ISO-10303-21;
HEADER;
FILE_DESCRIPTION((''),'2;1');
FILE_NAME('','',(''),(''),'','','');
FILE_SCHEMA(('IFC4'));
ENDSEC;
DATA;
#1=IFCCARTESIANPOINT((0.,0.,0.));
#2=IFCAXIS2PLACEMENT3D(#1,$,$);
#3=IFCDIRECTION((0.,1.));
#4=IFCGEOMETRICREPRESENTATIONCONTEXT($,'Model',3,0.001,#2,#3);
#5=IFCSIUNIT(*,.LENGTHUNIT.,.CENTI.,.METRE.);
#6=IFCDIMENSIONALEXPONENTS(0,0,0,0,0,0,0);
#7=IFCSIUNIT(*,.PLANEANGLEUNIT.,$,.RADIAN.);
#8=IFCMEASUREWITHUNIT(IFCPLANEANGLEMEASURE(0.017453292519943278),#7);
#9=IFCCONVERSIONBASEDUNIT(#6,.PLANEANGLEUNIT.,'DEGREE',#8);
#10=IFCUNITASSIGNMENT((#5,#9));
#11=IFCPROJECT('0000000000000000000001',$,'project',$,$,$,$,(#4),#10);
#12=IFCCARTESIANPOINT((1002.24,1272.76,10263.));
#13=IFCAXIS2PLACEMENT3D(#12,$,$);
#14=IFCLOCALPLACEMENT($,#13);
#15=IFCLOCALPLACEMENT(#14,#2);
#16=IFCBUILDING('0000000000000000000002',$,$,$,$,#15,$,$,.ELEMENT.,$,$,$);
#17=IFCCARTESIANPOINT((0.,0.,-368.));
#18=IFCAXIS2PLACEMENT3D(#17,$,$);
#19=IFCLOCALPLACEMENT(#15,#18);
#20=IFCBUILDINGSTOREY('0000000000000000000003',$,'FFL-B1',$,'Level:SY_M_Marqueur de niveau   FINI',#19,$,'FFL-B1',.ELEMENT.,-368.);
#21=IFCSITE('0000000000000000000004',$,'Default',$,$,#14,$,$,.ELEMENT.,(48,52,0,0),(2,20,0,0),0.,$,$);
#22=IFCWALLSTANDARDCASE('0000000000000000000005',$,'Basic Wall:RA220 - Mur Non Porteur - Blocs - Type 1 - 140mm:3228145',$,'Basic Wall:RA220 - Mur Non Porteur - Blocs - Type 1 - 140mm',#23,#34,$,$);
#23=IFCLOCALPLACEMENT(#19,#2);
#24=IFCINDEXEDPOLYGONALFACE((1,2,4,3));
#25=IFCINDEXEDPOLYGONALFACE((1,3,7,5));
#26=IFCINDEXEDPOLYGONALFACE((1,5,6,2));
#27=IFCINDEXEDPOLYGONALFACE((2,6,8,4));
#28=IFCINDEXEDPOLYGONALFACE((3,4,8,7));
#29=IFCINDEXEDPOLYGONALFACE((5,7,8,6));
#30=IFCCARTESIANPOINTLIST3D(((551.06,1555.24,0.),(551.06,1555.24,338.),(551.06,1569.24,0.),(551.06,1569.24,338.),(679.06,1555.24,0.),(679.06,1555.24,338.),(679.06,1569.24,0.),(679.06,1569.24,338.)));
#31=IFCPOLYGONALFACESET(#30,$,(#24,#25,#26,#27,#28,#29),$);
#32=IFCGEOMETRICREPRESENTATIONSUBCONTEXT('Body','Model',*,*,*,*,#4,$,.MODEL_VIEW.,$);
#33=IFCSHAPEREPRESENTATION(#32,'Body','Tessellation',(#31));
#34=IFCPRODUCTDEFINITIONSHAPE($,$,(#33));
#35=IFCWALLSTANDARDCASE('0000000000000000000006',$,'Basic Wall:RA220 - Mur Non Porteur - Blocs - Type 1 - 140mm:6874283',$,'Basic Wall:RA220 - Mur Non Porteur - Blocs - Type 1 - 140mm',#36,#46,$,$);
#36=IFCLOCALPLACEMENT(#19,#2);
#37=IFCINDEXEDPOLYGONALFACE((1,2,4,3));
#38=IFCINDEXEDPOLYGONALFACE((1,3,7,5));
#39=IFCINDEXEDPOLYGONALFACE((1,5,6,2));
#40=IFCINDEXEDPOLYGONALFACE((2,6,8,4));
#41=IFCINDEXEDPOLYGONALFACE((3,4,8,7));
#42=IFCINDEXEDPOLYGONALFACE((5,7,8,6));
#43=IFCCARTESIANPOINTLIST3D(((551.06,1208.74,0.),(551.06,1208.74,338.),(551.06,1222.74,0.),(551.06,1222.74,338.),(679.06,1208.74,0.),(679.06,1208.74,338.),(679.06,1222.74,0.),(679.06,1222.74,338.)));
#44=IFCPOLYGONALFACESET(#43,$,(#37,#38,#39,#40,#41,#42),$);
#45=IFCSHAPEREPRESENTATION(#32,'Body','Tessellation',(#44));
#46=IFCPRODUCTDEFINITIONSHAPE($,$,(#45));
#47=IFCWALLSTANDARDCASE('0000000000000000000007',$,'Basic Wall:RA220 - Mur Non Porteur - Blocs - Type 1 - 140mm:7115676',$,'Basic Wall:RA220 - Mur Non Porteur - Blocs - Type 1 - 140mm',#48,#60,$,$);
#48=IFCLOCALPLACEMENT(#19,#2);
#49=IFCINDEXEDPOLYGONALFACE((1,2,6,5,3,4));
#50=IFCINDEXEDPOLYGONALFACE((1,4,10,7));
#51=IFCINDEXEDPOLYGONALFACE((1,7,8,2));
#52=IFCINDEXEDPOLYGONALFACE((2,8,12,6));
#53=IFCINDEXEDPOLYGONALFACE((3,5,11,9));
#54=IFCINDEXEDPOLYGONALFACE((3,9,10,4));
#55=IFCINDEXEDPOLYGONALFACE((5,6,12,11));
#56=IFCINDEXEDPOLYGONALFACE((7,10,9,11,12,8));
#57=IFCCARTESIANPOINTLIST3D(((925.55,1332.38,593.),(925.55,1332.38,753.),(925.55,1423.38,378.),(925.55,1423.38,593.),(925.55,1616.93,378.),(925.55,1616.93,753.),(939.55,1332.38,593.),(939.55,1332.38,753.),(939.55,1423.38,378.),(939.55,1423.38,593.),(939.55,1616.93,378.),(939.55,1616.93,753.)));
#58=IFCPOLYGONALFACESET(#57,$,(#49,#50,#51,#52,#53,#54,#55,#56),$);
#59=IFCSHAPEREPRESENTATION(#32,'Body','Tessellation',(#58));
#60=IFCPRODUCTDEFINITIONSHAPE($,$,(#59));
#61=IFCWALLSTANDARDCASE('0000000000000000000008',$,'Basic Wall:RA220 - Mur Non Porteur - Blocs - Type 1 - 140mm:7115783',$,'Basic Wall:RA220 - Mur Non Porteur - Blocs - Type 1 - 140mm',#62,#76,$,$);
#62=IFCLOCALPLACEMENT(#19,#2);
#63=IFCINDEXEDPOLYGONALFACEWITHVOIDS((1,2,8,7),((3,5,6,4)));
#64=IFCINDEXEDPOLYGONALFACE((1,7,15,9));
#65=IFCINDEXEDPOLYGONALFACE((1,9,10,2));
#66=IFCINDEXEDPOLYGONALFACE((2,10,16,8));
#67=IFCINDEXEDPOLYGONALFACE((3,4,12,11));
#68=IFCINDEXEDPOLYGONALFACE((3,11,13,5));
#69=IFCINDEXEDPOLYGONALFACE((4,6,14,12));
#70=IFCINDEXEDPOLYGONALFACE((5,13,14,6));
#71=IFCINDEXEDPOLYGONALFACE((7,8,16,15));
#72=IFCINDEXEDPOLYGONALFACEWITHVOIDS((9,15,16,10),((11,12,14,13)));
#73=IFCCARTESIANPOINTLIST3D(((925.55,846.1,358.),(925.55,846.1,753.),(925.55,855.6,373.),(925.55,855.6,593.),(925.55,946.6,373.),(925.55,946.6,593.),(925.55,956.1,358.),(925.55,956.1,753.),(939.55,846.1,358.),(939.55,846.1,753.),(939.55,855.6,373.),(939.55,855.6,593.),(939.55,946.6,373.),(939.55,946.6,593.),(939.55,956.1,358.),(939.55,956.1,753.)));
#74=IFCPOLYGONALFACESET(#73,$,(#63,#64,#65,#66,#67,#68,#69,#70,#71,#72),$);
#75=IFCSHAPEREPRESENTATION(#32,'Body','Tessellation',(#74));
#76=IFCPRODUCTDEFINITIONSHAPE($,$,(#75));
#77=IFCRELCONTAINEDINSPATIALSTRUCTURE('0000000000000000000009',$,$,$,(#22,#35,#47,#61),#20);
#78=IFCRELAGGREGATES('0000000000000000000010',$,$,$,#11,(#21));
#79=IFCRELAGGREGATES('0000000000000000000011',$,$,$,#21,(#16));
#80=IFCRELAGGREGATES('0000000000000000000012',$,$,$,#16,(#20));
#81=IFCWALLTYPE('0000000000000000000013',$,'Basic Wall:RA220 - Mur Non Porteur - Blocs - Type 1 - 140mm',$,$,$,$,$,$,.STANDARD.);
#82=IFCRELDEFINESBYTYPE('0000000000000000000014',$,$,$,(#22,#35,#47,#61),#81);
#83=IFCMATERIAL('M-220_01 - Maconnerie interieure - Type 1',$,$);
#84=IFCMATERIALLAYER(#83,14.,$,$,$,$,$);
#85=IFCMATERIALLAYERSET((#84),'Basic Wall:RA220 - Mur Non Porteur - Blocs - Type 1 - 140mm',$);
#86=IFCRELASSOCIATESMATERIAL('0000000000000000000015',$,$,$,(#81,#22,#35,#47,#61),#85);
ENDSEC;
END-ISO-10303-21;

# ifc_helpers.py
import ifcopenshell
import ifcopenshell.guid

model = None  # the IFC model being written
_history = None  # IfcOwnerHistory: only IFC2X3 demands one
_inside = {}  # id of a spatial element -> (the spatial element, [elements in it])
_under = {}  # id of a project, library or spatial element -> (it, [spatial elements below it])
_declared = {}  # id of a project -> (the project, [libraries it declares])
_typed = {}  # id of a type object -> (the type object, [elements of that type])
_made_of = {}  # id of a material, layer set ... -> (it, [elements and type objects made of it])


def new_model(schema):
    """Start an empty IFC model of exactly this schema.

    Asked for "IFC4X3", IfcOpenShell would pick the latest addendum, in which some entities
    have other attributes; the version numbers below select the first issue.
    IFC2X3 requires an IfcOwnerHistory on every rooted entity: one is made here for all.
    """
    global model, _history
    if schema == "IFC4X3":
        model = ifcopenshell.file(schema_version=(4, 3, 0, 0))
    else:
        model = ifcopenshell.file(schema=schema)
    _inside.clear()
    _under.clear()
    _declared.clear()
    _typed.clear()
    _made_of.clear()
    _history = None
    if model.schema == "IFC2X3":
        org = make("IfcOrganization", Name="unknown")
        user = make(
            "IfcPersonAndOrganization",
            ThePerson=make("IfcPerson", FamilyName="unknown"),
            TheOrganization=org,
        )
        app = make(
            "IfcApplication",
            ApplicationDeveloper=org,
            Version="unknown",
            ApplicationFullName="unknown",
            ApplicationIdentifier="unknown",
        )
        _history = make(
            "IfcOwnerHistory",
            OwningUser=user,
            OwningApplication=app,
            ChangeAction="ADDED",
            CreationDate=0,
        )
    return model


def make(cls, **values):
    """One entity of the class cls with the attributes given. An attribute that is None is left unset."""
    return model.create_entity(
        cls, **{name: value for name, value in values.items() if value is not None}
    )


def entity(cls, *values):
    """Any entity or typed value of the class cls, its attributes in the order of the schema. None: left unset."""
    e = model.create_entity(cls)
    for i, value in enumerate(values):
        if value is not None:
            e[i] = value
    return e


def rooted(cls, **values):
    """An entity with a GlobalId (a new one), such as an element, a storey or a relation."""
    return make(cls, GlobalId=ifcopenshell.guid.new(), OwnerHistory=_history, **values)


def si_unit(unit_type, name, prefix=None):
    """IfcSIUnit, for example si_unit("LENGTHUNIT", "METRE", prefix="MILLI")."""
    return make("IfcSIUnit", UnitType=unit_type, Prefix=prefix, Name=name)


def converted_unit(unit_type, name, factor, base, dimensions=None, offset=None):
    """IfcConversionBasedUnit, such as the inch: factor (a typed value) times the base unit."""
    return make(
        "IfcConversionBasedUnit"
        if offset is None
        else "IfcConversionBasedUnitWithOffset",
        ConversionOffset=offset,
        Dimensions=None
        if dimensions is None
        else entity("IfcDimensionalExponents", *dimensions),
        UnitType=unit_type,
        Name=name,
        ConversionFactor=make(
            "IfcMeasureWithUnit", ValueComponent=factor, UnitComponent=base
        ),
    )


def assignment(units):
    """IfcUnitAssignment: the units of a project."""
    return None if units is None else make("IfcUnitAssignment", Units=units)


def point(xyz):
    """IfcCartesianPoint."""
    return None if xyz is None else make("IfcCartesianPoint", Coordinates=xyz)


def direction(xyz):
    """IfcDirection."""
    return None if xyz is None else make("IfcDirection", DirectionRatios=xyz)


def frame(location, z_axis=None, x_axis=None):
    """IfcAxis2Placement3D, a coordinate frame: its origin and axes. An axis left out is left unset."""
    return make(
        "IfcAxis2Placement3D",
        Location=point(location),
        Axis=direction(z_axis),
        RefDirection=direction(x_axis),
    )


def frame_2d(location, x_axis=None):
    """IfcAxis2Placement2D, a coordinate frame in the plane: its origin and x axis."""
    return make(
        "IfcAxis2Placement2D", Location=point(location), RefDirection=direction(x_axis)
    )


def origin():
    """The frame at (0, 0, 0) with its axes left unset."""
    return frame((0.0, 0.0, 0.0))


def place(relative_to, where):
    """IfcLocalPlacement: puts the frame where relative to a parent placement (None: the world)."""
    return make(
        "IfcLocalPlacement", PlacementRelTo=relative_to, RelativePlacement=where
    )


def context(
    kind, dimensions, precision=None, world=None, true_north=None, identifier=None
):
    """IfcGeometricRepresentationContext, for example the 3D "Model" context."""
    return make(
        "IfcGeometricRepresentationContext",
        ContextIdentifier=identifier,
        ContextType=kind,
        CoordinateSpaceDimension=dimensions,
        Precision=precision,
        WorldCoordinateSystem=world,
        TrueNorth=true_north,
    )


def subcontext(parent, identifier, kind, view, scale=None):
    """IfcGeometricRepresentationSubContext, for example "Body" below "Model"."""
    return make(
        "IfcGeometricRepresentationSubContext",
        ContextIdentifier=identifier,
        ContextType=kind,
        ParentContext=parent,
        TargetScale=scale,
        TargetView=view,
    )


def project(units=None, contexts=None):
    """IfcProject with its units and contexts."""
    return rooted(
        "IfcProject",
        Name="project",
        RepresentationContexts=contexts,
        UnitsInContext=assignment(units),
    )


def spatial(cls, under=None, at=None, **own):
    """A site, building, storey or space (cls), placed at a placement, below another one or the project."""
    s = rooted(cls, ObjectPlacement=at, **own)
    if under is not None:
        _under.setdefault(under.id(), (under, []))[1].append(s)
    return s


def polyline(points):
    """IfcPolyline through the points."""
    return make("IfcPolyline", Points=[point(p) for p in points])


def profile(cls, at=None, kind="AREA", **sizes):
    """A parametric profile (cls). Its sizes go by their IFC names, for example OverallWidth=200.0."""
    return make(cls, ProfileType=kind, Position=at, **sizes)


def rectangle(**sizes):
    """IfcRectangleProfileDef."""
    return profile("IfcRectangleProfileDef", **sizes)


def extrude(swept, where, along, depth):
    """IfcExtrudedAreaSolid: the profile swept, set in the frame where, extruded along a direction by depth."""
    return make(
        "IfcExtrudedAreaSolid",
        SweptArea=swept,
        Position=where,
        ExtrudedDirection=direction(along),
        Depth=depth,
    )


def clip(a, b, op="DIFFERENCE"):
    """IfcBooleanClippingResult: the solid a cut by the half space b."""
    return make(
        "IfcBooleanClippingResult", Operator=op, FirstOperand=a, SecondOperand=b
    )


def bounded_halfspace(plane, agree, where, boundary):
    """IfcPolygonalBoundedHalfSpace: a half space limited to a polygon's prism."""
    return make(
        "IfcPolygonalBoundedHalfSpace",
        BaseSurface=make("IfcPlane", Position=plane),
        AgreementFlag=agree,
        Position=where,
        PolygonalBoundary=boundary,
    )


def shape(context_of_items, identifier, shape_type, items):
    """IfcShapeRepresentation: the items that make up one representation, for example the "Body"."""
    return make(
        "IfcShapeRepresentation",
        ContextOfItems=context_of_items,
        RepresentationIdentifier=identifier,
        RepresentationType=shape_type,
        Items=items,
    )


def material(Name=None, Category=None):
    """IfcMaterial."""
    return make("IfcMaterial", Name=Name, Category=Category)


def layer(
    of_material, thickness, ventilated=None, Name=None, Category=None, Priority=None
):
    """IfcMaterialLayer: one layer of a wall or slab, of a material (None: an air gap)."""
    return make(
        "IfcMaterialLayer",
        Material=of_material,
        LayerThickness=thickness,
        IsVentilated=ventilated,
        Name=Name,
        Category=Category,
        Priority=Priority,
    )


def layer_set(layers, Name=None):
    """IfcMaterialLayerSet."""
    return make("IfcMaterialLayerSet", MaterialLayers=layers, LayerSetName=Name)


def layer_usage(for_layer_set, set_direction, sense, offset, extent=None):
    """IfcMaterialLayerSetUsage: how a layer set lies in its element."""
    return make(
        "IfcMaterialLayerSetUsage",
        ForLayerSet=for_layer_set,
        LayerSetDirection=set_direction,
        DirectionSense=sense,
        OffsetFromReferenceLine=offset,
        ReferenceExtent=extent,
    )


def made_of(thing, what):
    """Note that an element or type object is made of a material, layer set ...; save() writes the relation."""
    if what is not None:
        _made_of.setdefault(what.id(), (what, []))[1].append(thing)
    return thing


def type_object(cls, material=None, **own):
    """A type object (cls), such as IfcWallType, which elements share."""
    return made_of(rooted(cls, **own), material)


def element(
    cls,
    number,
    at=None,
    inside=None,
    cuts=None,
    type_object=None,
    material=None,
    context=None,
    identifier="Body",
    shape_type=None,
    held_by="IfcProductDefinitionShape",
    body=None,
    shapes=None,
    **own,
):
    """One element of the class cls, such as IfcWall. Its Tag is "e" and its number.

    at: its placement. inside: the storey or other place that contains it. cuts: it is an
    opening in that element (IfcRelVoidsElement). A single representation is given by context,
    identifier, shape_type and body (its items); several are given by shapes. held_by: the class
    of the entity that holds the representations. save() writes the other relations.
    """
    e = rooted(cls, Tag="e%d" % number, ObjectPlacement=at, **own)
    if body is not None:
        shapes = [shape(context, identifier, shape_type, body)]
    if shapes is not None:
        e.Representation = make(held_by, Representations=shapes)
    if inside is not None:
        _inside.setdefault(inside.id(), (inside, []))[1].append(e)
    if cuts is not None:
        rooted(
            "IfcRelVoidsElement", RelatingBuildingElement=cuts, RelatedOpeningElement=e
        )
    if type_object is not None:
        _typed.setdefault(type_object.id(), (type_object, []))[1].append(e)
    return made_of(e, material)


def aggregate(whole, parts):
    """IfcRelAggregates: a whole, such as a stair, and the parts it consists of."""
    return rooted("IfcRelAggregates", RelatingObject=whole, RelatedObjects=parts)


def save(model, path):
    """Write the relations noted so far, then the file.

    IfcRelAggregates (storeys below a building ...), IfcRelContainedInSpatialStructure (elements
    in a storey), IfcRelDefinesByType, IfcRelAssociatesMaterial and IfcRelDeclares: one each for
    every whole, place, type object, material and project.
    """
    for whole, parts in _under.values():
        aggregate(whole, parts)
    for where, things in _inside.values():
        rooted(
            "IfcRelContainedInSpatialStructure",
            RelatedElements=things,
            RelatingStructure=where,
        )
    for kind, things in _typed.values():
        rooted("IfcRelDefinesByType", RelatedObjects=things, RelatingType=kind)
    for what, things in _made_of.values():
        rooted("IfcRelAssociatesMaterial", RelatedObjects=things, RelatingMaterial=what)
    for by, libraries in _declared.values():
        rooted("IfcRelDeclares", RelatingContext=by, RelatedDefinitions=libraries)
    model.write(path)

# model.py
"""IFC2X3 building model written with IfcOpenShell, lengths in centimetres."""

from ifc_helpers import new_model, entity, si_unit, converted_unit, direction, frame, frame_2d, origin, place, context, subcontext, project, spatial, polyline, rectangle, extrude, clip, bounded_halfspace, material, layer, layer_set, layer_usage, type_object, element, save


model = new_model("IFC2X3")

# Units and contexts
model_context = context("Model", 3, precision=0.001, world=origin(), true_north=direction((0.0, 1.0)))
body_context = subcontext(model_context, "Body", "Model", "MODEL_VIEW")
ifc_project = project(units=[si_unit("LENGTHUNIT", "METRE", prefix="CENTI"), converted_unit("PLANEANGLEUNIT", "DEGREE", entity("IfcPlaneAngleMeasure", 0.017453292519943278), si_unit("PLANEANGLEUNIT", "RADIAN"), dimensions=[0, 0, 0, 0, 0, 0, 0])], contexts=[model_context])

# Site, building, storey
site_placement = place(None, frame((1002.24, 1272.76, 10263.0)))
site = spatial("IfcSite", under=ifc_project, at=site_placement, Name="Default", CompositionType="ELEMENT", RefLatitude=(48, 52, 0, 0), RefLongitude=(2, 20, 0, 0), RefElevation=0.0)
building_placement = place(site_placement, origin())
building = spatial("IfcBuilding", under=site, at=building_placement, CompositionType="ELEMENT")
storey_placement = place(building_placement, frame((0.0, 0.0, -368.0)))
storey = spatial("IfcBuildingStorey", under=building, at=storey_placement, Name="FFL-B1", ObjectType="Level:SY_M_Marqueur de niveau   FINI", LongName="FFL-B1", CompositionType="ELEMENT", Elevation=-368.0)

# Walls
ifc_material_1 = material(Name="M-220_01 - Maconnerie interieure - Type 1")
ifc_layer_1 = layer(ifc_material_1, 14.0)
ifc_layer_set_1 = layer_set([ifc_layer_1], Name="Basic Wall:RA220 - Mur Non Porteur - Blocs - Type 1 - 140mm")
ifc_layer_usage_1 = layer_usage(ifc_layer_set_1, "AXIS2", "NEGATIVE", 7.0)
wall_type_1 = type_object("IfcWallType", Name="Basic Wall:RA220 - Mur Non Porteur - Blocs - Type 1 - 140mm", PredefinedType="STANDARD", material=ifc_layer_set_1)
wall_1_placement = place(storey_placement, frame((679.06, 1562.24, 0.0), z_axis=(0.0, 0.0, 1.0), x_axis=(-1.0, 0.0, 0.0)))
element("IfcWallStandardCase", 1, at=wall_1_placement, inside=storey, type_object=wall_type_1, material=ifc_layer_usage_1, Name="Basic Wall:RA220 - Mur Non Porteur - Blocs - Type 1 - 140mm:3228145", ObjectType="Basic Wall:RA220 - Mur Non Porteur - Blocs - Type 1 - 140mm", context=body_context, shape_type="Clipping", body=[
    clip(extrude(rectangle(XDim=128.0, YDim=14.0, at=frame_2d((64.0, 0.0), x_axis=(-1.0, 0.0))), origin(), (0.0, 0.0, 1.0), 338.0), bounded_halfspace(frame((0.0, -7.0, 338.0), z_axis=(0.0, 0.0, -1.0), x_axis=(-1.0, 0.0, 0.0)), True, frame((0.0, -7.0, 338.0), z_axis=(0.0, 0.0, -1.0), x_axis=(-1.0, 0.0, 0.0)), polyline([(0.0, 0.0), (0.0, 14.0), (-7.5, 14.0), (-128.0, 14.0), (-128.0, 0.0), (-7.5, 0.0), (0.0, 0.0)]))),
])
ifc_layer_usage_2 = layer_usage(ifc_layer_set_1, "AXIS2", "NEGATIVE", 7.0)
wall_2_placement = place(storey_placement, frame((679.06, 1215.74, 0.0), z_axis=(0.0, 0.0, 1.0), x_axis=(-1.0, 0.0, 0.0)))
element("IfcWallStandardCase", 2, at=wall_2_placement, inside=storey, type_object=wall_type_1, material=ifc_layer_usage_2, Name="Basic Wall:RA220 - Mur Non Porteur - Blocs - Type 1 - 140mm:6874283", ObjectType="Basic Wall:RA220 - Mur Non Porteur - Blocs - Type 1 - 140mm", context=body_context, shape_type="Clipping", body=[
    clip(extrude(rectangle(XDim=128.0, YDim=14.0, at=frame_2d((64.0, 0.0), x_axis=(-1.0, 0.0))), origin(), (0.0, 0.0, 1.0), 338.0), bounded_halfspace(frame((0.0, -7.0, 338.0), z_axis=(0.0, 0.0, -1.0), x_axis=(-1.0, 0.0, 0.0)), True, frame((0.0, -7.0, 338.0), z_axis=(0.0, 0.0, -1.0), x_axis=(-1.0, 0.0, 0.0)), polyline([(0.0, 0.0), (0.0, 14.0), (-7.5, 14.0), (-128.0, 14.0), (-128.0, 0.0), (-7.5, 0.0), (0.0, 0.0)]))),
])

# Walls, openings
ifc_layer_usage_3 = layer_usage(ifc_layer_set_1, "AXIS2", "POSITIVE", -7.0)
wall_3_placement = place(storey_placement, frame((932.55, 1616.93, 378.0), z_axis=(0.0, 0.0, 1.0), x_axis=(0.0, -1.0, 0.0)))
wall_3 = element("IfcWallStandardCase", 3, at=wall_3_placement, inside=storey, type_object=wall_type_1, material=ifc_layer_usage_3, Name="Basic Wall:RA220 - Mur Non Porteur - Blocs - Type 1 - 140mm:7115676", ObjectType="Basic Wall:RA220 - Mur Non Porteur - Blocs - Type 1 - 140mm", context=body_context, shape_type="SweptSolid", body=[
    extrude(rectangle(XDim=284.55, YDim=14.0, at=frame_2d((142.27, 0.0), x_axis=(-1.0, 0.0))), origin(), (0.0, 0.0, 1.0), 375.0),
])
opening_1_placement = place(wall_3_placement, frame((1616.93, -932.55, 0.0), z_axis=(0.0, 0.0, 1.0), x_axis=(0.0, 1.0, 0.0)))
element("IfcOpeningElement", 4, at=opening_1_placement, cuts=wall_3, ObjectType="Opening", context=body_context, shape_type="SweptSolid", body=[
    extrude(rectangle(XDim=215.0, YDim=91.0, at=frame_2d((0.0, 0.0), x_axis=(0.0, 1.0))), frame((925.55, 1377.88, 107.5), z_axis=(1.0, 0.0, 0.0), x_axis=(0.0, -1.0, 0.0)), (0.0, 0.0, 1.0), 14.0),
])
ifc_layer_usage_4 = layer_usage(ifc_layer_set_1, "AXIS2", "POSITIVE", -7.0)
wall_4_placement = place(storey_placement, frame((932.55, 956.1, 358.0), z_axis=(0.0, 0.0, 1.0), x_axis=(0.0, -1.0, 0.0)))
wall_4 = element("IfcWallStandardCase", 5, at=wall_4_placement, inside=storey, type_object=wall_type_1, material=ifc_layer_usage_4, Name="Basic Wall:RA220 - Mur Non Porteur - Blocs - Type 1 - 140mm:7115783", ObjectType="Basic Wall:RA220 - Mur Non Porteur - Blocs - Type 1 - 140mm", context=body_context, shape_type="SweptSolid", body=[
    extrude(rectangle(XDim=110.0, YDim=14.0, at=frame_2d((55.0, 0.0), x_axis=(-1.0, 0.0))), origin(), (0.0, 0.0, 1.0), 395.0),
])
opening_2_placement = place(wall_4_placement, frame((956.1, -932.55, 20.0), z_axis=(0.0, 0.0, 1.0), x_axis=(0.0, 1.0, 0.0)))
element("IfcOpeningElement", 6, at=opening_2_placement, cuts=wall_4, ObjectType="Opening", context=body_context, shape_type="SweptSolid", body=[
    extrude(rectangle(XDim=220.0, YDim=91.0, at=frame_2d((0.0, 0.0), x_axis=(0.0, 1.0))), frame((925.55, 901.1, 105.0), z_axis=(1.0, 0.0, 0.0), x_axis=(0.0, -1.0, 0.0)), (0.0, 0.0, 1.0), 14.0),
])

save(model, "model.ifc")
